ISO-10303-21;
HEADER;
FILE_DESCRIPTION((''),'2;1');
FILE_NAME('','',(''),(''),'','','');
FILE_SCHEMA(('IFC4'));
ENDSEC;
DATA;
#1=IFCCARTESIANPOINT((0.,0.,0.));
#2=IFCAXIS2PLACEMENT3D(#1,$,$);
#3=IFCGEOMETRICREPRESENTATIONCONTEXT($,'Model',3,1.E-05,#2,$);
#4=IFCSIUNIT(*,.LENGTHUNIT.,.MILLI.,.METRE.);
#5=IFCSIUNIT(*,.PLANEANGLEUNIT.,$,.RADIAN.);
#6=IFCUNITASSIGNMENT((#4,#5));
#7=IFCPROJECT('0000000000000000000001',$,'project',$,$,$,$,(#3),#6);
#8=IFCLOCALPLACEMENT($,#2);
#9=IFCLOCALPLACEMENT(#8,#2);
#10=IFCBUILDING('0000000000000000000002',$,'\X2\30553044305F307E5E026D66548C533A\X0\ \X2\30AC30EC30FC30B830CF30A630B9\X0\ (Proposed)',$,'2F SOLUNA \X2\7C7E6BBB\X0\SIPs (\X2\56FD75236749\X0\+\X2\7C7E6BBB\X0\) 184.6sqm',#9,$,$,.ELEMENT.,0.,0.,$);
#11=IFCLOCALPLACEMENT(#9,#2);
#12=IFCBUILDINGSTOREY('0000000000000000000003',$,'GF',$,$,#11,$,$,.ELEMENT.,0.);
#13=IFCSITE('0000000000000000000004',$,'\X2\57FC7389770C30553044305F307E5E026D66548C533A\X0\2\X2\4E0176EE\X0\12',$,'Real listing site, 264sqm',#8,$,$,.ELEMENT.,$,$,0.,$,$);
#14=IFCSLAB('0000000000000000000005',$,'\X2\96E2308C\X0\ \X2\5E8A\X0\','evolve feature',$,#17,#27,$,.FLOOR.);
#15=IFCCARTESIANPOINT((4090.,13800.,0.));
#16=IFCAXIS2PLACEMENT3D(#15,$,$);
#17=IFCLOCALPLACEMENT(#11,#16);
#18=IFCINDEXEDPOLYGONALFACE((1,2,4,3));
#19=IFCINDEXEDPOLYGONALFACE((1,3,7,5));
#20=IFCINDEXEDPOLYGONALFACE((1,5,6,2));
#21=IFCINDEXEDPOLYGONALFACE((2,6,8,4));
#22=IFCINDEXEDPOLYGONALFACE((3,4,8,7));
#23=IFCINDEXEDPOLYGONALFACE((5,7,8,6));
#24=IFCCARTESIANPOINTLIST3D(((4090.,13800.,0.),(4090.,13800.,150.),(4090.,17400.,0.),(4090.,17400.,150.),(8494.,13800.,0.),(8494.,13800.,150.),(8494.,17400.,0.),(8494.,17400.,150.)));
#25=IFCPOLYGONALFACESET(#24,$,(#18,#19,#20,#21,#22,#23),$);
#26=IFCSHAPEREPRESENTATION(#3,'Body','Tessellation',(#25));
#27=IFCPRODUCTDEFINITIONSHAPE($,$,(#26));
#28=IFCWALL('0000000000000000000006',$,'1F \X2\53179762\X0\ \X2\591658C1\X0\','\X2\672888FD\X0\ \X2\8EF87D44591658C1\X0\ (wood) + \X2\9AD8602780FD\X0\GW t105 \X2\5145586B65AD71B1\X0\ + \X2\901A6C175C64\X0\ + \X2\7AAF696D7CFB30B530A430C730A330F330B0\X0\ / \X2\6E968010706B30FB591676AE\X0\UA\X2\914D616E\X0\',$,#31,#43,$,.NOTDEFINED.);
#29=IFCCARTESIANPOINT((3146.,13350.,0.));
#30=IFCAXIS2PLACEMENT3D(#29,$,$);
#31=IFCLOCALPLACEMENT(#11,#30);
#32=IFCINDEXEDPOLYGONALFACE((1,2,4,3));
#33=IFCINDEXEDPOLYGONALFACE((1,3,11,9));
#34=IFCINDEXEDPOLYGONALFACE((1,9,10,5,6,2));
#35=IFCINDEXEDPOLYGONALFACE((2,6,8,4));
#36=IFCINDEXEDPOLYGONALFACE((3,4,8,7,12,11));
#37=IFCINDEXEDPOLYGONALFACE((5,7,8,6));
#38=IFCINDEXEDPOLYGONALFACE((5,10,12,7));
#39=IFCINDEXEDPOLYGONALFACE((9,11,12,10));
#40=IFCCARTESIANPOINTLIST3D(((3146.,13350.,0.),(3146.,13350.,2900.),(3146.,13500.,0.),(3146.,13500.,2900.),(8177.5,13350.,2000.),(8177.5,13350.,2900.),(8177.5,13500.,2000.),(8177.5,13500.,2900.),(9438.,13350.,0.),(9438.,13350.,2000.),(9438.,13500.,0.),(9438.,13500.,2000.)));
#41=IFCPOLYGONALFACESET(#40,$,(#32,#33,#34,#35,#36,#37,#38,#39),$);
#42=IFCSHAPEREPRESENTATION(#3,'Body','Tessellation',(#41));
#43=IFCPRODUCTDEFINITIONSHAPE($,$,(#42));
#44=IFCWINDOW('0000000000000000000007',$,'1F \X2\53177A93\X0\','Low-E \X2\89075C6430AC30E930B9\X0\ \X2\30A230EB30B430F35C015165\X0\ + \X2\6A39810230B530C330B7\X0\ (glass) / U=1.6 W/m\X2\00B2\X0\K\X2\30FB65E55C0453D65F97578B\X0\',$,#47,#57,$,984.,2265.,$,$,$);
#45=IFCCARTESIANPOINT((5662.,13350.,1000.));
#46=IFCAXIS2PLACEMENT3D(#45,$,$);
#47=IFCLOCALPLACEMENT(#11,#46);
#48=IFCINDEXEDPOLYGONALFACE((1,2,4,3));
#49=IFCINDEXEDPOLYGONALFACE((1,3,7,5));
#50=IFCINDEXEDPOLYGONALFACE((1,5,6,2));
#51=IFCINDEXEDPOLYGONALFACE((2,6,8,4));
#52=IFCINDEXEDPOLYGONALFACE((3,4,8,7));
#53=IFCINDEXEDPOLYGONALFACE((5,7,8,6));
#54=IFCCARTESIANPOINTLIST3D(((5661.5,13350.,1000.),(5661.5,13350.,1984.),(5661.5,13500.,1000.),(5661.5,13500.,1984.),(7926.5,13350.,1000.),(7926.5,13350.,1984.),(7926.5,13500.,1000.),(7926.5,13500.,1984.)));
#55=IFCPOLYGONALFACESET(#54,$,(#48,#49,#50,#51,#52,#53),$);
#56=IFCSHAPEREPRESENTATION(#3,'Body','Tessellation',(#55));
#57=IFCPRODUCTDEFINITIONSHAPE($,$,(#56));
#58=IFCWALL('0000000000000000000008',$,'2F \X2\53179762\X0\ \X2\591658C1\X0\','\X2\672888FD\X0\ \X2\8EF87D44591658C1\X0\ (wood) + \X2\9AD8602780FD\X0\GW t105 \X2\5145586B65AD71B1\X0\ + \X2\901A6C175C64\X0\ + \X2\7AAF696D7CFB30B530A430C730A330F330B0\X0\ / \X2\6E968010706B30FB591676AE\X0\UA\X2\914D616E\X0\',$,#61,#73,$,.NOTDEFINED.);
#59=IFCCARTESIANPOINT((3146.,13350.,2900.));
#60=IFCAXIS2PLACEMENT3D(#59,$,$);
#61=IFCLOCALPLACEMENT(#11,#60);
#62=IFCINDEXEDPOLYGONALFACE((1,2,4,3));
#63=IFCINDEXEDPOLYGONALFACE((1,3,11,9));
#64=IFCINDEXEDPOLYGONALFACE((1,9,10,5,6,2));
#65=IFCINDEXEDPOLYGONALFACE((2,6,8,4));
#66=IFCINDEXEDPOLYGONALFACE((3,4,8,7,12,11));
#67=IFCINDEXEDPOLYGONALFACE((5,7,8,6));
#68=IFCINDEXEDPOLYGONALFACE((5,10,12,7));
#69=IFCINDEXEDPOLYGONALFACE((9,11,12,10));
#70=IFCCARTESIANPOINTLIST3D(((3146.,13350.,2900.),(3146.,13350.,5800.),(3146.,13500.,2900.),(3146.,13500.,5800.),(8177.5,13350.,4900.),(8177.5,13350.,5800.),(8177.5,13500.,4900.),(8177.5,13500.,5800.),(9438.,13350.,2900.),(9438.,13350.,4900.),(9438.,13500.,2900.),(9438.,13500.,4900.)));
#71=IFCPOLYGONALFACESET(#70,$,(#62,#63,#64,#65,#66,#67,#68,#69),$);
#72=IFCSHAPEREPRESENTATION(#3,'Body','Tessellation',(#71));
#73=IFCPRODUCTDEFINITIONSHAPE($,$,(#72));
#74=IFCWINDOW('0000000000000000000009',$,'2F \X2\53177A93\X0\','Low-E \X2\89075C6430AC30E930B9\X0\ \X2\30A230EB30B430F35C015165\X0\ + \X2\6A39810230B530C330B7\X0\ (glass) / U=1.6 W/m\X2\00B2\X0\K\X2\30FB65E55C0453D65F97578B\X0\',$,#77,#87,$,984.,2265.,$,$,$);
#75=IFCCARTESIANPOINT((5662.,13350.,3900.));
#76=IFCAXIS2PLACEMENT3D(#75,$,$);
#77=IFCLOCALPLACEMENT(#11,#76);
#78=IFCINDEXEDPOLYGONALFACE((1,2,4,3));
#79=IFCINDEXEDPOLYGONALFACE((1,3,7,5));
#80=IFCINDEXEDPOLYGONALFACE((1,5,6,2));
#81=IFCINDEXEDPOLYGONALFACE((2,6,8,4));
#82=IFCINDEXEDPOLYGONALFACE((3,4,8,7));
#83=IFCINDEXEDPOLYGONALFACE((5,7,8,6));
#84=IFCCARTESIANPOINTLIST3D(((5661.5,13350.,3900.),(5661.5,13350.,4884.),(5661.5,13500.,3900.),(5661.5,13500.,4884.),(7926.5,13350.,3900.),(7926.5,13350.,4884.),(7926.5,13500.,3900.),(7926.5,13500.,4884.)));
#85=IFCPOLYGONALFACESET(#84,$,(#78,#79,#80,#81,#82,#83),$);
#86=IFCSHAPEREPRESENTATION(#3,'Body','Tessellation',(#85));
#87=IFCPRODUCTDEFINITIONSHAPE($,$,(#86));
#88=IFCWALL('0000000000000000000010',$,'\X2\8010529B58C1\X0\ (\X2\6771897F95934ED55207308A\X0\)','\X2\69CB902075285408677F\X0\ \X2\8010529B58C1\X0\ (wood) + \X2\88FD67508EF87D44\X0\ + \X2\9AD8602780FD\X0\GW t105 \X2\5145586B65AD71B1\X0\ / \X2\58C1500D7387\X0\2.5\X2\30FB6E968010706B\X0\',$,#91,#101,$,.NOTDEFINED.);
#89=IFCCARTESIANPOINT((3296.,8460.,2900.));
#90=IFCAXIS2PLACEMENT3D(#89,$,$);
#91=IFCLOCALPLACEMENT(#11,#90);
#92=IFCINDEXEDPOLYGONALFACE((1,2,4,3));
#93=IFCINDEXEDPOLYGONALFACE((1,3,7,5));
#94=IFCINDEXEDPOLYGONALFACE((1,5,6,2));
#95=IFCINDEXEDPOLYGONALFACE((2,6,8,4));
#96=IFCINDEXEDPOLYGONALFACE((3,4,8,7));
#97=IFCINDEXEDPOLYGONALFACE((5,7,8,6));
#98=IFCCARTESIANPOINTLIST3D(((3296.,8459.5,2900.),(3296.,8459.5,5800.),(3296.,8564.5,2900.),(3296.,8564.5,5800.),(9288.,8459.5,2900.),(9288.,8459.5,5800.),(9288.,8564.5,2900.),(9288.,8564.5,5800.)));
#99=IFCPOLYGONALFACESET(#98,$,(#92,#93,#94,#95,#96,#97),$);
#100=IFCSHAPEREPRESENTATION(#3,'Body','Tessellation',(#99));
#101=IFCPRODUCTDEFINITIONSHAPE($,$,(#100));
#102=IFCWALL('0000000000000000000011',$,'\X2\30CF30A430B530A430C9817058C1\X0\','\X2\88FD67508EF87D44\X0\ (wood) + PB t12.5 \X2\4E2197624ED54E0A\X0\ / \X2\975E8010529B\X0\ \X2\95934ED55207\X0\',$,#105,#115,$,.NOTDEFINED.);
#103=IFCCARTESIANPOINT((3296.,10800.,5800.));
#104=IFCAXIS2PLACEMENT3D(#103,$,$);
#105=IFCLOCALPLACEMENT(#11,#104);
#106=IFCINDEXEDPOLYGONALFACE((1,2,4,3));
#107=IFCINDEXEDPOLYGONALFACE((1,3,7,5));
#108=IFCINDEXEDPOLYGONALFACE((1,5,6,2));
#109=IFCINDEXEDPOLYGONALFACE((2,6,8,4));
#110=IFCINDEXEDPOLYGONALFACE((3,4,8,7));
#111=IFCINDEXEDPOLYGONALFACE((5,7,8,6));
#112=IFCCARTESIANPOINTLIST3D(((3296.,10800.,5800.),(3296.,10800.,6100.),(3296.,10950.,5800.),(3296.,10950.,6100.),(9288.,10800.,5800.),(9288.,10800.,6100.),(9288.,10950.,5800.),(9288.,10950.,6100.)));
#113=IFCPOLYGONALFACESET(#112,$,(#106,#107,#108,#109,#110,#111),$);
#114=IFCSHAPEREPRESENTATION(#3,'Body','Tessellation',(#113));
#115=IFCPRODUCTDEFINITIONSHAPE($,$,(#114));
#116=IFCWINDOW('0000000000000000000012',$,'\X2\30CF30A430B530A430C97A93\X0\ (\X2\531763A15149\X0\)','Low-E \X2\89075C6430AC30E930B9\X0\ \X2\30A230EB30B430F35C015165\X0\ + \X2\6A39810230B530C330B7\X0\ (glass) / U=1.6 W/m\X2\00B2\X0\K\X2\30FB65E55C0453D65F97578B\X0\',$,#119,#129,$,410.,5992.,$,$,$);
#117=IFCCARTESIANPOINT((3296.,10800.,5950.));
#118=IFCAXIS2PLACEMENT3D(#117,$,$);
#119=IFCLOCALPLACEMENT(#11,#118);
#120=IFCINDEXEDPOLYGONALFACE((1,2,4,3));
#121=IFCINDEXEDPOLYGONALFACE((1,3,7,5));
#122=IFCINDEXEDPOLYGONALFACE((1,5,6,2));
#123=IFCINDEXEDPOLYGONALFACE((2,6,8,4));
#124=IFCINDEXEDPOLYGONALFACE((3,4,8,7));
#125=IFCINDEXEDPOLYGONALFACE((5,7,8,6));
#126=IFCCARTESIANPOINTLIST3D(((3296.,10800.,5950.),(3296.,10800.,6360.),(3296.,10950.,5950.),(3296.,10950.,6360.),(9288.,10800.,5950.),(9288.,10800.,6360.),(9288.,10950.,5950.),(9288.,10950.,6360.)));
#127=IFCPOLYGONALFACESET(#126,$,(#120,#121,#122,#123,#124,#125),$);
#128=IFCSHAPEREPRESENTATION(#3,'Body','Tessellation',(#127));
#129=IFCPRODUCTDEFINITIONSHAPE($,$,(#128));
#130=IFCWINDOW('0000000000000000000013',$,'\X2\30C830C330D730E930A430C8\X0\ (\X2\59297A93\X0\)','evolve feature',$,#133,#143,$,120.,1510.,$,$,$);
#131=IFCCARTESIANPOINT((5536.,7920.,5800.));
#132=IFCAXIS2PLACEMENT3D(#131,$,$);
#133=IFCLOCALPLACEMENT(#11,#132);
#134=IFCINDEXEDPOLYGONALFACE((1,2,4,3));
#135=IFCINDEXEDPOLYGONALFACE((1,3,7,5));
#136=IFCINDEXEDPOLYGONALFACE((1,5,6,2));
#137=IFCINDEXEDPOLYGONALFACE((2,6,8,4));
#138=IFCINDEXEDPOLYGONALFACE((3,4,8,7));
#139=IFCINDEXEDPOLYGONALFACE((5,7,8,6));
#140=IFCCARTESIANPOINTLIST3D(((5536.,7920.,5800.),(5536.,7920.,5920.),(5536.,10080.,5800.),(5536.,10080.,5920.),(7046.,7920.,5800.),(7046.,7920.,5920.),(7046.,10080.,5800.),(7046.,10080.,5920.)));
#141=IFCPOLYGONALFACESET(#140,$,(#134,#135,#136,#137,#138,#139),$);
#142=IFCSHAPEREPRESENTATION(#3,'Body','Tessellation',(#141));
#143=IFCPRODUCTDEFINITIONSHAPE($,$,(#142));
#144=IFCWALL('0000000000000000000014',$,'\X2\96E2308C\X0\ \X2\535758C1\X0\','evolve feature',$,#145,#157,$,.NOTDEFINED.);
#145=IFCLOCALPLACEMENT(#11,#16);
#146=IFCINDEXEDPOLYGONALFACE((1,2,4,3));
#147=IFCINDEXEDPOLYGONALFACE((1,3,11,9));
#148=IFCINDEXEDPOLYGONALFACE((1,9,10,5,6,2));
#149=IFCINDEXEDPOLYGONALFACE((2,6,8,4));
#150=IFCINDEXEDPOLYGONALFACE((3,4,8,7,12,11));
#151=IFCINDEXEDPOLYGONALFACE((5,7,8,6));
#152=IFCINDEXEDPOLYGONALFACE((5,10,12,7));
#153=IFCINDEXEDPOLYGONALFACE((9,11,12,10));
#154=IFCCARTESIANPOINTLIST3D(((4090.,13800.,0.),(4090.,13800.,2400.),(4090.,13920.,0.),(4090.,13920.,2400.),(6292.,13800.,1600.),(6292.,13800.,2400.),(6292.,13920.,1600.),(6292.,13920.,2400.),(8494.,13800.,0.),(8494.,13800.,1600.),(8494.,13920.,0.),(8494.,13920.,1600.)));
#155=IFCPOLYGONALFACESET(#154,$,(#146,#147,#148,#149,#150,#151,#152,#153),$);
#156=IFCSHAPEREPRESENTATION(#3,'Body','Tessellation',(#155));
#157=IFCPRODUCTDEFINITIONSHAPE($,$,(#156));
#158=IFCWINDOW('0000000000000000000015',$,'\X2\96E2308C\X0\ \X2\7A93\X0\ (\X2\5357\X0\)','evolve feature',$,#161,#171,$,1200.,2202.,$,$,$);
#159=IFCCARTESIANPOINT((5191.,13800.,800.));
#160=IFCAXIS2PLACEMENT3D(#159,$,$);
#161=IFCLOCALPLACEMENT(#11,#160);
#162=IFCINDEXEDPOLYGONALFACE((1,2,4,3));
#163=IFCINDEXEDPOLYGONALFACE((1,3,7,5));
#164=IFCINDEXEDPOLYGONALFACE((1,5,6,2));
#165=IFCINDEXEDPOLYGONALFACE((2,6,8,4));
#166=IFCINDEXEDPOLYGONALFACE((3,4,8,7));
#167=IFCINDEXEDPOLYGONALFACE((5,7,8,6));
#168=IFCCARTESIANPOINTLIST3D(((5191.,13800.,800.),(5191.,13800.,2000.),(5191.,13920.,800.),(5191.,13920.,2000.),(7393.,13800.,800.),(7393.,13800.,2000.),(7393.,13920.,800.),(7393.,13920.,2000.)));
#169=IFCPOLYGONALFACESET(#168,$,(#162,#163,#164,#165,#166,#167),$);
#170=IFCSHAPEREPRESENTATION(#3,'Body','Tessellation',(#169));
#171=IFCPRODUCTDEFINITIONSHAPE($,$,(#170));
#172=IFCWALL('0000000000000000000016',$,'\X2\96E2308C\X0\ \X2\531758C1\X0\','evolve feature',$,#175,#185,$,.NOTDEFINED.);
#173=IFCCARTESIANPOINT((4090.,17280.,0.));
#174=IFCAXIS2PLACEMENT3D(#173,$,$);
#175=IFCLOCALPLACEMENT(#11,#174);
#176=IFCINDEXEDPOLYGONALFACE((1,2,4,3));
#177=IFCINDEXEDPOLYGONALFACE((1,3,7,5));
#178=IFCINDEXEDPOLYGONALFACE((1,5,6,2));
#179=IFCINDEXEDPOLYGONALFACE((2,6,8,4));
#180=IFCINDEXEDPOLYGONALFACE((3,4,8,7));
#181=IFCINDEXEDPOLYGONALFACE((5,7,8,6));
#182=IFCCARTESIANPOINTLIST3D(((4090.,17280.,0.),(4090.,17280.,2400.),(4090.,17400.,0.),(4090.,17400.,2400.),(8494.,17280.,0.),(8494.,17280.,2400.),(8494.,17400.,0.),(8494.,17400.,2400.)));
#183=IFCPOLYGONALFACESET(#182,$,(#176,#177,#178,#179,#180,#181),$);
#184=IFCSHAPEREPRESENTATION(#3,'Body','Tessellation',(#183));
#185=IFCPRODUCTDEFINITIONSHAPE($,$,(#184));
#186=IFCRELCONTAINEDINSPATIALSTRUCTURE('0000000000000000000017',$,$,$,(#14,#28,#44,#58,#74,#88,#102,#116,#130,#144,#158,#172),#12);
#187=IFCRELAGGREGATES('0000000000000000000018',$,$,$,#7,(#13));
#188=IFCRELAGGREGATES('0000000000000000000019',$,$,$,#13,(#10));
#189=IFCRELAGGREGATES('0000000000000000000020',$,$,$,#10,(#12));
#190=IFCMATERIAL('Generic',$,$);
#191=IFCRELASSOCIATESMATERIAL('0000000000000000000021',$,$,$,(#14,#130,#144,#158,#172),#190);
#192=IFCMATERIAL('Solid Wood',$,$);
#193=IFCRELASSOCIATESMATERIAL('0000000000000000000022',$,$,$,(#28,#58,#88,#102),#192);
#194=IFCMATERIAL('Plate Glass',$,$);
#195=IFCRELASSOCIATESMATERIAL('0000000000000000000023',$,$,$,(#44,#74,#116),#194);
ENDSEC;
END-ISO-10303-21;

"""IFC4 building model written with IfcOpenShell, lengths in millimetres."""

from ifc_helpers import new_model, si_unit, frame, frame_2d, origin, place, context, project, spatial, rectangle, extrude, material, element, fill, save


model = new_model("IFC4")

# Units and contexts
model_context = context("Model", 3, precision=1e-05, world=origin())
ifc_project = project(units=[si_unit("LENGTHUNIT", "METRE", prefix="MILLI"), si_unit("PLANEANGLEUNIT", "RADIAN")], contexts=[model_context])

# Site, building, storey
site_placement = place(None, origin())
site = spatial("IfcSite", under=ifc_project, at=site_placement, Name="埼玉県さいたま市浦和区2丁目12", ObjectType="Real listing site, 264sqm", CompositionType="ELEMENT", RefElevation=0.0)
building_placement = place(site_placement, origin())
building = spatial("IfcBuilding", under=site, at=building_placement, Name="さいたま市浦和区 ガレージハウス (Proposed)", ObjectType="2F SOLUNA 籾殻SIPs (国産杉+籾殻) 184.6sqm", CompositionType="ELEMENT", ElevationOfRefHeight=0.0, ElevationOfTerrain=0.0)
storey_placement = place(building_placement, origin())
storey = spatial("IfcBuildingStorey", under=building, at=storey_placement, Name="GF", CompositionType="ELEMENT", Elevation=0.0)

# Slab
ifc_material_1 = material(Name="Generic")
slab_placement = place(storey_placement, frame((4090.0, 13800.0, 0.0)))
element("IfcSlab", 1, at=slab_placement, inside=storey, material=ifc_material_1, Name="離れ 床", Description="evolve feature", PredefinedType="FLOOR", context=model_context, shape_type="SweptSolid", body=[
    extrude(rectangle(XDim=4404.0, YDim=3600.0, at=frame_2d((2202.0, 1800.0))), frame((4090.0, 13800.0, 0.0)), (0.0, 0.0, 1.0), 150.0),
])

# Wall, opening, window
ifc_material_2 = material(Name="Solid Wood")
wall_1_placement = place(storey_placement, frame((3146.0, 13350.0, 0.0)))
wall_1 = element("IfcWall", 2, at=wall_1_placement, inside=storey, material=ifc_material_2, Name="1F 北面 外壁", Description="木製 軸組外壁 (wood) + 高性能GW t105 充填断熱 + 通気層 + 窯業系サイディング / 準耐火・外皮UA配慮", PredefinedType="NOTDEFINED", context=model_context, shape_type="SweptSolid", body=[
    extrude(rectangle(XDim=6292.0, YDim=150.0, at=frame_2d((3146.0, 75.0))), frame((3146.0, 13350.0, 0.0)), (0.0, 0.0, 1.0), 2900.0),
])
opening_1_placement = place(storey_placement, frame((5662.0, 13350.0, 1000.0)))
opening_1 = element("IfcOpeningElement", 3, at=opening_1_placement, cuts=wall_1, PredefinedType="NOTDEFINED", context=model_context, shape_type="SweptSolid", body=[
    extrude(rectangle(XDim=2265.0, YDim=150.0, at=frame_2d((1132.0, 75.0))), frame((5662.0, 13350.0, 1000.0)), (0.0, 0.0, 1.0), 984.0),
])
ifc_material_3 = material(Name="Plate Glass")
window_1_placement = place(storey_placement, frame((5662.0, 13350.0, 1000.0)))
window_1 = element("IfcWindow", 4, at=window_1_placement, inside=storey, material=ifc_material_3, Name="1F 北窓", Description="Low-E 複層ガラス アルゴン封入 + 樹脂サッシ (glass) / U=1.6 W/m²K・日射取得型", OverallHeight=984.0, OverallWidth=2265.0, context=model_context, shape_type="SweptSolid", body=[
    extrude(rectangle(XDim=2265.0, YDim=150.0, at=frame_2d((1132.0, 75.0))), frame((5662.0, 13350.0, 1000.0)), (0.0, 0.0, 1.0), 984.0),
])
fill(opening_1, window_1)

# Wall, opening, window
wall_2_placement = place(storey_placement, frame((3146.0, 13350.0, 2900.0)))
wall_2 = element("IfcWall", 5, at=wall_2_placement, inside=storey, material=ifc_material_2, Name="2F 北面 外壁", Description="木製 軸組外壁 (wood) + 高性能GW t105 充填断熱 + 通気層 + 窯業系サイディング / 準耐火・外皮UA配慮", PredefinedType="NOTDEFINED", context=model_context, shape_type="SweptSolid", body=[
    extrude(rectangle(XDim=6292.0, YDim=150.0, at=frame_2d((3146.0, 75.0))), frame((3146.0, 13350.0, 2900.0)), (0.0, 0.0, 1.0), 2900.0),
])
opening_2_placement = place(storey_placement, frame((5662.0, 13350.0, 3900.0)))
opening_2 = element("IfcOpeningElement", 6, at=opening_2_placement, cuts=wall_2, PredefinedType="NOTDEFINED", context=model_context, shape_type="SweptSolid", body=[
    extrude(rectangle(XDim=2265.0, YDim=150.0, at=frame_2d((1132.0, 75.0))), frame((5662.0, 13350.0, 3900.0)), (0.0, 0.0, 1.0), 984.0),
])
window_2_placement = place(storey_placement, frame((5662.0, 13350.0, 3900.0)))
window_2 = element("IfcWindow", 7, at=window_2_placement, inside=storey, material=ifc_material_3, Name="2F 北窓", Description="Low-E 複層ガラス アルゴン封入 + 樹脂サッシ (glass) / U=1.6 W/m²K・日射取得型", OverallHeight=984.0, OverallWidth=2265.0, context=model_context, shape_type="SweptSolid", body=[
    extrude(rectangle(XDim=2265.0, YDim=150.0, at=frame_2d((1132.0, 75.0))), frame((5662.0, 13350.0, 3900.0)), (0.0, 0.0, 1.0), 984.0),
])
fill(opening_2, window_2)

# Wall
wall_3_placement = place(storey_placement, frame((3296.0, 8460.0, 2900.0)))
element("IfcWall", 8, at=wall_3_placement, inside=storey, material=ifc_material_2, Name="耐力壁 (東西間仕切り)", Description="構造用合板 耐力壁 (wood) + 製材軸組 + 高性能GW t105 充填断熱 / 壁倍率2.5・準耐火", PredefinedType="NOTDEFINED", context=model_context, shape_type="SweptSolid", body=[
    extrude(rectangle(XDim=5992.0, YDim=105.0, at=frame_2d((2996.0, 52.0))), frame((3296.0, 8460.0, 2900.0)), (0.0, 0.0, 1.0), 2900.0),
])

# Wall, opening, window
wall_4_placement = place(storey_placement, frame((3296.0, 10800.0, 5800.0)))
wall_4 = element("IfcWall", 9, at=wall_4_placement, inside=storey, material=ifc_material_2, Name="ハイサイド腰壁", Description="製材軸組 (wood) + PB t12.5 両面仕上 / 非耐力 間仕切", PredefinedType="NOTDEFINED", context=model_context, shape_type="SweptSolid", body=[
    extrude(rectangle(XDim=5992.0, YDim=150.0, at=frame_2d((2996.0, 75.0))), frame((3296.0, 10800.0, 5800.0)), (0.0, 0.0, 1.0), 700.0),
])
opening_3_placement = place(storey_placement, frame((3296.0, 10800.0, 5950.0)))
opening_3 = element("IfcOpeningElement", 10, at=opening_3_placement, cuts=wall_4, PredefinedType="NOTDEFINED", context=model_context, shape_type="SweptSolid", body=[
    extrude(rectangle(XDim=5992.0, YDim=150.0, at=frame_2d((2996.0, 75.0))), frame((3296.0, 10800.0, 5950.0)), (0.0, 0.0, 1.0), 410.0),
])
window_3_placement = place(storey_placement, frame((3296.0, 10800.0, 5950.0)))
window_3 = element("IfcWindow", 11, at=window_3_placement, inside=storey, material=ifc_material_3, Name="ハイサイド窓 (北採光)", Description="Low-E 複層ガラス アルゴン封入 + 樹脂サッシ (glass) / U=1.6 W/m²K・日射取得型", OverallHeight=410.0, OverallWidth=5992.0, context=model_context, shape_type="SweptSolid", body=[
    extrude(rectangle(XDim=5992.0, YDim=150.0, at=frame_2d((2996.0, 75.0))), frame((3296.0, 10800.0, 5950.0)), (0.0, 0.0, 1.0), 410.0),
])
fill(opening_3, window_3)

# Window
window_4_placement = place(storey_placement, frame((5536.0, 7920.0, 5800.0)))
element("IfcWindow", 12, at=window_4_placement, inside=storey, material=ifc_material_1, Name="トップライト (天窓)", Description="evolve feature", OverallHeight=120.0, OverallWidth=1510.0, context=model_context, shape_type="SweptSolid", body=[
    extrude(rectangle(XDim=1510.0, YDim=2160.0, at=frame_2d((755.0, 1080.0))), frame((5536.0, 7920.0, 5800.0)), (0.0, 0.0, 1.0), 120.0),
])

# Wall, opening, window
wall_5_placement = place(storey_placement, frame((4090.0, 13800.0, 0.0)))
wall_5 = element("IfcWall", 13, at=wall_5_placement, inside=storey, material=ifc_material_1, Name="離れ 南壁", Description="evolve feature", PredefinedType="NOTDEFINED", context=model_context, shape_type="SweptSolid", body=[
    extrude(rectangle(XDim=4404.0, YDim=120.0, at=frame_2d((2202.0, 60.0))), frame((4090.0, 13800.0, 0.0)), (0.0, 0.0, 1.0), 2400.0),
])
opening_4_placement = place(storey_placement, frame((5191.0, 13800.0, 800.0)))
opening_4 = element("IfcOpeningElement", 14, at=opening_4_placement, cuts=wall_5, PredefinedType="NOTDEFINED", context=model_context, shape_type="SweptSolid", body=[
    extrude(rectangle(XDim=2202.0, YDim=120.0, at=frame_2d((1101.0, 60.0))), frame((5191.0, 13800.0, 800.0)), (0.0, 0.0, 1.0), 1200.0),
])
window_5_placement = place(storey_placement, frame((5191.0, 13800.0, 800.0)))
window_5 = element("IfcWindow", 15, at=window_5_placement, inside=storey, material=ifc_material_1, Name="離れ 窓 (南)", Description="evolve feature", OverallHeight=1200.0, OverallWidth=2202.0, context=model_context, shape_type="SweptSolid", body=[
    extrude(rectangle(XDim=2202.0, YDim=120.0, at=frame_2d((1101.0, 60.0))), frame((5191.0, 13800.0, 800.0)), (0.0, 0.0, 1.0), 1200.0),
])
fill(opening_4, window_5)

# Wall
wall_6_placement = place(storey_placement, frame((4090.0, 17280.0, 0.0)))
element("IfcWall", 16, at=wall_6_placement, inside=storey, material=ifc_material_1, Name="離れ 北壁", Description="evolve feature", PredefinedType="NOTDEFINED", context=model_context, shape_type="SweptSolid", body=[
    extrude(rectangle(XDim=4404.0, YDim=120.0, at=frame_2d((2202.0, 60.0))), frame((4090.0, 17280.0, 0.0)), (0.0, 0.0, 1.0), 2400.0),
])

save(model, "model.ifc")
